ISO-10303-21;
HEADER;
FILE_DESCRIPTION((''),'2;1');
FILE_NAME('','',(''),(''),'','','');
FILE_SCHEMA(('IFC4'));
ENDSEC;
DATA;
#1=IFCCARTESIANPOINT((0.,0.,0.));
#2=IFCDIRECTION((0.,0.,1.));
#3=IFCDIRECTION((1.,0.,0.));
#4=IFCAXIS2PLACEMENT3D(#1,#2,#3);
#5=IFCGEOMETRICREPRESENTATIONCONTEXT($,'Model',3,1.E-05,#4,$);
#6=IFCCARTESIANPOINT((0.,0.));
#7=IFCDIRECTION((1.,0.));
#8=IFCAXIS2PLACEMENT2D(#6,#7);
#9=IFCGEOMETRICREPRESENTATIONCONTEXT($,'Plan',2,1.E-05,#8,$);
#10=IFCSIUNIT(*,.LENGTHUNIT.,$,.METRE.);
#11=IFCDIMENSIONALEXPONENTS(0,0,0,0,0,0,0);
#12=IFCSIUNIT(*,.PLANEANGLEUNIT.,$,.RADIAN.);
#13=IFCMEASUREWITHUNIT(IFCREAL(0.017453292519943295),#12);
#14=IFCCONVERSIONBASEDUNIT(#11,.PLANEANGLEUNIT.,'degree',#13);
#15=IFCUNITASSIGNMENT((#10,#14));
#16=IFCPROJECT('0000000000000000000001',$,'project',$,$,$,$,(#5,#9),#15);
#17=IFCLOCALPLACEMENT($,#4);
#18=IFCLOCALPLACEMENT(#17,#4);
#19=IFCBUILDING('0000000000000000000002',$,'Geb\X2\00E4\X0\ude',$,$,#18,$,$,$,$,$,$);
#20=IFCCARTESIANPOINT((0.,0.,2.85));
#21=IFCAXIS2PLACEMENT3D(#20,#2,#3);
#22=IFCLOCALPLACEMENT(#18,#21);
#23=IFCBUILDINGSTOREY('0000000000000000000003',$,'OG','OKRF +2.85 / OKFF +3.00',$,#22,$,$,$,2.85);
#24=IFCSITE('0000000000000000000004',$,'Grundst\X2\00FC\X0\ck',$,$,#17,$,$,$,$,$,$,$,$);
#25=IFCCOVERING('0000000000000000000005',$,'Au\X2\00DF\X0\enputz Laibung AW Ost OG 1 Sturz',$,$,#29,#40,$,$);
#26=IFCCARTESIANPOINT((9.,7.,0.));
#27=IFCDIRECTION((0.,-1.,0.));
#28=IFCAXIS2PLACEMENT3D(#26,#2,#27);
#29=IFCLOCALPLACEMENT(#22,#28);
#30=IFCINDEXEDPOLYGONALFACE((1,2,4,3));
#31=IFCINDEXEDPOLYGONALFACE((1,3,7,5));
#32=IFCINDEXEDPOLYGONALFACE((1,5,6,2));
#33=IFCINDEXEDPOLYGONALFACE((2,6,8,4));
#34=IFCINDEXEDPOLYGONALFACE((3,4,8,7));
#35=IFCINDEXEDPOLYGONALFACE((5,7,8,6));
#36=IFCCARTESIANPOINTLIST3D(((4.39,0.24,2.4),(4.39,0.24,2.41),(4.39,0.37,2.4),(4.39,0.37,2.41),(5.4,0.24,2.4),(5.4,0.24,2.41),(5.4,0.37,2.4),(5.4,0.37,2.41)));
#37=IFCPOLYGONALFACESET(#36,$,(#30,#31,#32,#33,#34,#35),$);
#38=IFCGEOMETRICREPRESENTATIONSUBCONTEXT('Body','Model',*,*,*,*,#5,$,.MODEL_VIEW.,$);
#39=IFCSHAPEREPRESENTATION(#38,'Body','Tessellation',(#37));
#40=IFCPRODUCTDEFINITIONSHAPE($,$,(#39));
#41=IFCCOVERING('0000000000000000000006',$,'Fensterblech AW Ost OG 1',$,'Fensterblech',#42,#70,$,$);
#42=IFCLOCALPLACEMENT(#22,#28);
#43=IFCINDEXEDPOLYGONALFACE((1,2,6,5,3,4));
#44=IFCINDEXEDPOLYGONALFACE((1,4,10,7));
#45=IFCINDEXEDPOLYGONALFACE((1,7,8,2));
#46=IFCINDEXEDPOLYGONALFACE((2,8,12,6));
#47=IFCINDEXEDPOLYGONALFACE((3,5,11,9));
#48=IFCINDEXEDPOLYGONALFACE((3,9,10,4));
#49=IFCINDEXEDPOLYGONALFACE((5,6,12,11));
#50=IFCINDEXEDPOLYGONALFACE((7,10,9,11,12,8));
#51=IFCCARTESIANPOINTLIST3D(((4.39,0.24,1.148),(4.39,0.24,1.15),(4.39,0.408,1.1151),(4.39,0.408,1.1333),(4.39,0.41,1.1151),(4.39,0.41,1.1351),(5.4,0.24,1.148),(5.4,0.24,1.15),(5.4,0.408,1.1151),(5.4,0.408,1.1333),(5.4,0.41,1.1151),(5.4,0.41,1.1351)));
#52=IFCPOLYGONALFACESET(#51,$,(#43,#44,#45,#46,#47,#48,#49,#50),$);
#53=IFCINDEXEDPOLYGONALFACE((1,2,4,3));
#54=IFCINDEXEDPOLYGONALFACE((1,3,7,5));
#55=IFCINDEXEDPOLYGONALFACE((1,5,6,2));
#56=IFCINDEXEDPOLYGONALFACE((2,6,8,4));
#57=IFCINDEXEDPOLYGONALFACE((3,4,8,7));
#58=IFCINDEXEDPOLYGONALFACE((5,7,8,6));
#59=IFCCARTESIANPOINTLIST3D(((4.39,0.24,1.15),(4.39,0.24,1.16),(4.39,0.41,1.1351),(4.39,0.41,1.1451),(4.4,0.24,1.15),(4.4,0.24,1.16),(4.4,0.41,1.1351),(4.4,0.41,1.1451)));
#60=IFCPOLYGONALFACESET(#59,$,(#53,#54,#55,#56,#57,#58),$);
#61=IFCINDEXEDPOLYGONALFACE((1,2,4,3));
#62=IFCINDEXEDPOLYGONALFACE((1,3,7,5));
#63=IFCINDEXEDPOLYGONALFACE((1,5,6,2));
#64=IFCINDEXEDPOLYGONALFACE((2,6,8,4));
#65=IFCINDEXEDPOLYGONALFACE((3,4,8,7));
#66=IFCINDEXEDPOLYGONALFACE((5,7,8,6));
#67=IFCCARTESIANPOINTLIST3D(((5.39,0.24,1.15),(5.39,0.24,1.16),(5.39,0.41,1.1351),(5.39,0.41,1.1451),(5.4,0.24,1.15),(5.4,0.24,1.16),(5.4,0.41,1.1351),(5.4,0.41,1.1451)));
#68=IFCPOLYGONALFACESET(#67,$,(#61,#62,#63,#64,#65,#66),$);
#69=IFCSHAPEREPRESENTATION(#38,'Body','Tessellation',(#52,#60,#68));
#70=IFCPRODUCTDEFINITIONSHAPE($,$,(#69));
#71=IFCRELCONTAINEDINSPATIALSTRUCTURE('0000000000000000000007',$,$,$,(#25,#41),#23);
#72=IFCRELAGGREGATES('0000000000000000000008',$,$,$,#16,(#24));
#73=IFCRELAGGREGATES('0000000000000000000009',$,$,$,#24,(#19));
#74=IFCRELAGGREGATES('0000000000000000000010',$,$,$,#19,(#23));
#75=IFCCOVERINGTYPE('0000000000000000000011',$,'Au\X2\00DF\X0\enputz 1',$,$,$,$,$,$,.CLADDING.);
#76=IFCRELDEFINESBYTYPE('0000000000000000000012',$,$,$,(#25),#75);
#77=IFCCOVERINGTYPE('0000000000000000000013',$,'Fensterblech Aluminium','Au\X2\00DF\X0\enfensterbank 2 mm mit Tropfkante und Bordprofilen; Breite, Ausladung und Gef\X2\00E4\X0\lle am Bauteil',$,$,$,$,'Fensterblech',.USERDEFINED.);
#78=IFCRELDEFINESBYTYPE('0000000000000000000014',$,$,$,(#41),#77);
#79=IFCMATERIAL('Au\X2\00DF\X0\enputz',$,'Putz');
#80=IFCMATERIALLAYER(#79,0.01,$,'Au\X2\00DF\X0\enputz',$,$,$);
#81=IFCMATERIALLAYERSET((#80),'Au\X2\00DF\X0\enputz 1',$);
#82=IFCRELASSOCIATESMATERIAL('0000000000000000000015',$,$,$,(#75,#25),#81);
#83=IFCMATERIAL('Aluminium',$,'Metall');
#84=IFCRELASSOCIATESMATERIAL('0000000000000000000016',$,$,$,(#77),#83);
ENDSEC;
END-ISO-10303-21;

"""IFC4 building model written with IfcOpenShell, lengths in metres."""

from ifc_helpers import new_model, entity, si_unit, converted_unit, frame, origin_with_axes, origin_2d_with_axis, place, context, subcontext, project, spatial, polyline, outline, extrude, material, layer, layer_set, layer_usage, type_object, element, save


model = new_model("IFC4")

# Units and contexts
model_context = context("Model", 3, precision=1e-05, world=origin_with_axes())
plan_context = context("Plan", 2, precision=1e-05, world=origin_2d_with_axis())
body_context = subcontext(model_context, "Body", "Model", "MODEL_VIEW")
ifc_project = project(units=[si_unit("LENGTHUNIT", "METRE"), converted_unit("PLANEANGLEUNIT", "degree", entity("IfcReal", 0.017453292519943295), si_unit("PLANEANGLEUNIT", "RADIAN"), dimensions=[0, 0, 0, 0, 0, 0, 0])], contexts=[model_context, plan_context])

# Site, building, storey
site_placement = place(None, origin_with_axes())
site = spatial("IfcSite", under=ifc_project, at=site_placement, Name="Grundstück")
building_placement = place(site_placement, origin_with_axes())
building = spatial("IfcBuilding", under=site, at=building_placement, Name="Gebäude")
storey_placement = place(building_placement, frame((0.0, 0.0, 2.85), z_axis=(0.0, 0.0, 1.0), x_axis=(1.0, 0.0, 0.0)))
storey = spatial("IfcBuildingStorey", under=building, at=storey_placement, Name="OG", Description="OKRF +2.85 / OKFF +3.00", Elevation=2.85)

# Covering
ifc_material_1 = material(Name="Außenputz", Category="Putz")
ifc_layer_1 = layer(ifc_material_1, 0.01, Name="Außenputz")
ifc_layer_set_1 = layer_set([ifc_layer_1], Name="Außenputz 1")
ifc_layer_usage_1 = layer_usage(ifc_layer_set_1, "AXIS3", "POSITIVE", 2.4)
covering_type_1 = type_object("IfcCoveringType", Name="Außenputz 1", PredefinedType="CLADDING", material=ifc_layer_set_1)
covering_1_placement = place(storey_placement, frame((9.0, 7.0, 0.0), z_axis=(0.0, 0.0, 1.0), x_axis=(0.0, -1.0, 0.0)))
element("IfcCovering", 1, at=covering_1_placement, inside=storey, type_object=covering_type_1, material=ifc_layer_usage_1, Name="Außenputz Laibung AW Ost OG 1 Sturz", context=body_context, shape_type="SweptSolid", body=[
    extrude(outline(polyline([(0.24, 2.4), (0.37, 2.4), (0.37, 2.41), (0.24, 2.41), (0.24, 2.4)])), frame((4.39, 0.0, 0.0), z_axis=(1.0, 0.0, 0.0), x_axis=(0.0, 1.0, 0.0)), (0.0, 0.0, 1.0), 1.01),
])

# Covering
ifc_material_2 = material(Name="Aluminium", Category="Metall")
covering_type_2 = type_object("IfcCoveringType", Name="Fensterblech Aluminium", Description="Außenfensterbank 2 mm mit Tropfkante und Bordprofilen; Breite, Ausladung und Gefälle am Bauteil", ElementType="Fensterblech", PredefinedType="USERDEFINED", material=ifc_material_2)
covering_2_placement = place(storey_placement, frame((9.0, 7.0, 0.0), z_axis=(0.0, 0.0, 1.0), x_axis=(0.0, -1.0, 0.0)))
element("IfcCovering", 2, at=covering_2_placement, inside=storey, type_object=covering_type_2, Name="Fensterblech AW Ost OG 1", ObjectType="Fensterblech", context=body_context, shape_type="SweptSolid", body=[
    extrude(outline(polyline([(0.24, 1.148), (0.408, 1.1333), (0.408, 1.1151), (0.41, 1.1151), (0.41, 1.1351), (0.24, 1.15), (0.24, 1.148)])), frame((4.39, 0.0, 0.0), z_axis=(1.0, 0.0, 0.0), x_axis=(0.0, 1.0, 0.0)), (0.0, 0.0, 1.0), 1.01),
    extrude(outline(polyline([(0.24, 1.15), (0.41, 1.1351), (0.41, 1.1451), (0.24, 1.16), (0.24, 1.15)])), frame((4.39, 0.0, 0.0), z_axis=(1.0, 0.0, 0.0), x_axis=(0.0, 1.0, 0.0)), (0.0, 0.0, 1.0), 0.01),
    extrude(outline(polyline([(0.24, 1.15), (0.41, 1.1351), (0.41, 1.1451), (0.24, 1.16), (0.24, 1.15)])), frame((5.39, 0.0, 0.0), z_axis=(1.0, 0.0, 0.0), x_axis=(0.0, 1.0, 0.0)), (0.0, 0.0, 1.0), 0.01),
])

save(model, "model.ifc")
